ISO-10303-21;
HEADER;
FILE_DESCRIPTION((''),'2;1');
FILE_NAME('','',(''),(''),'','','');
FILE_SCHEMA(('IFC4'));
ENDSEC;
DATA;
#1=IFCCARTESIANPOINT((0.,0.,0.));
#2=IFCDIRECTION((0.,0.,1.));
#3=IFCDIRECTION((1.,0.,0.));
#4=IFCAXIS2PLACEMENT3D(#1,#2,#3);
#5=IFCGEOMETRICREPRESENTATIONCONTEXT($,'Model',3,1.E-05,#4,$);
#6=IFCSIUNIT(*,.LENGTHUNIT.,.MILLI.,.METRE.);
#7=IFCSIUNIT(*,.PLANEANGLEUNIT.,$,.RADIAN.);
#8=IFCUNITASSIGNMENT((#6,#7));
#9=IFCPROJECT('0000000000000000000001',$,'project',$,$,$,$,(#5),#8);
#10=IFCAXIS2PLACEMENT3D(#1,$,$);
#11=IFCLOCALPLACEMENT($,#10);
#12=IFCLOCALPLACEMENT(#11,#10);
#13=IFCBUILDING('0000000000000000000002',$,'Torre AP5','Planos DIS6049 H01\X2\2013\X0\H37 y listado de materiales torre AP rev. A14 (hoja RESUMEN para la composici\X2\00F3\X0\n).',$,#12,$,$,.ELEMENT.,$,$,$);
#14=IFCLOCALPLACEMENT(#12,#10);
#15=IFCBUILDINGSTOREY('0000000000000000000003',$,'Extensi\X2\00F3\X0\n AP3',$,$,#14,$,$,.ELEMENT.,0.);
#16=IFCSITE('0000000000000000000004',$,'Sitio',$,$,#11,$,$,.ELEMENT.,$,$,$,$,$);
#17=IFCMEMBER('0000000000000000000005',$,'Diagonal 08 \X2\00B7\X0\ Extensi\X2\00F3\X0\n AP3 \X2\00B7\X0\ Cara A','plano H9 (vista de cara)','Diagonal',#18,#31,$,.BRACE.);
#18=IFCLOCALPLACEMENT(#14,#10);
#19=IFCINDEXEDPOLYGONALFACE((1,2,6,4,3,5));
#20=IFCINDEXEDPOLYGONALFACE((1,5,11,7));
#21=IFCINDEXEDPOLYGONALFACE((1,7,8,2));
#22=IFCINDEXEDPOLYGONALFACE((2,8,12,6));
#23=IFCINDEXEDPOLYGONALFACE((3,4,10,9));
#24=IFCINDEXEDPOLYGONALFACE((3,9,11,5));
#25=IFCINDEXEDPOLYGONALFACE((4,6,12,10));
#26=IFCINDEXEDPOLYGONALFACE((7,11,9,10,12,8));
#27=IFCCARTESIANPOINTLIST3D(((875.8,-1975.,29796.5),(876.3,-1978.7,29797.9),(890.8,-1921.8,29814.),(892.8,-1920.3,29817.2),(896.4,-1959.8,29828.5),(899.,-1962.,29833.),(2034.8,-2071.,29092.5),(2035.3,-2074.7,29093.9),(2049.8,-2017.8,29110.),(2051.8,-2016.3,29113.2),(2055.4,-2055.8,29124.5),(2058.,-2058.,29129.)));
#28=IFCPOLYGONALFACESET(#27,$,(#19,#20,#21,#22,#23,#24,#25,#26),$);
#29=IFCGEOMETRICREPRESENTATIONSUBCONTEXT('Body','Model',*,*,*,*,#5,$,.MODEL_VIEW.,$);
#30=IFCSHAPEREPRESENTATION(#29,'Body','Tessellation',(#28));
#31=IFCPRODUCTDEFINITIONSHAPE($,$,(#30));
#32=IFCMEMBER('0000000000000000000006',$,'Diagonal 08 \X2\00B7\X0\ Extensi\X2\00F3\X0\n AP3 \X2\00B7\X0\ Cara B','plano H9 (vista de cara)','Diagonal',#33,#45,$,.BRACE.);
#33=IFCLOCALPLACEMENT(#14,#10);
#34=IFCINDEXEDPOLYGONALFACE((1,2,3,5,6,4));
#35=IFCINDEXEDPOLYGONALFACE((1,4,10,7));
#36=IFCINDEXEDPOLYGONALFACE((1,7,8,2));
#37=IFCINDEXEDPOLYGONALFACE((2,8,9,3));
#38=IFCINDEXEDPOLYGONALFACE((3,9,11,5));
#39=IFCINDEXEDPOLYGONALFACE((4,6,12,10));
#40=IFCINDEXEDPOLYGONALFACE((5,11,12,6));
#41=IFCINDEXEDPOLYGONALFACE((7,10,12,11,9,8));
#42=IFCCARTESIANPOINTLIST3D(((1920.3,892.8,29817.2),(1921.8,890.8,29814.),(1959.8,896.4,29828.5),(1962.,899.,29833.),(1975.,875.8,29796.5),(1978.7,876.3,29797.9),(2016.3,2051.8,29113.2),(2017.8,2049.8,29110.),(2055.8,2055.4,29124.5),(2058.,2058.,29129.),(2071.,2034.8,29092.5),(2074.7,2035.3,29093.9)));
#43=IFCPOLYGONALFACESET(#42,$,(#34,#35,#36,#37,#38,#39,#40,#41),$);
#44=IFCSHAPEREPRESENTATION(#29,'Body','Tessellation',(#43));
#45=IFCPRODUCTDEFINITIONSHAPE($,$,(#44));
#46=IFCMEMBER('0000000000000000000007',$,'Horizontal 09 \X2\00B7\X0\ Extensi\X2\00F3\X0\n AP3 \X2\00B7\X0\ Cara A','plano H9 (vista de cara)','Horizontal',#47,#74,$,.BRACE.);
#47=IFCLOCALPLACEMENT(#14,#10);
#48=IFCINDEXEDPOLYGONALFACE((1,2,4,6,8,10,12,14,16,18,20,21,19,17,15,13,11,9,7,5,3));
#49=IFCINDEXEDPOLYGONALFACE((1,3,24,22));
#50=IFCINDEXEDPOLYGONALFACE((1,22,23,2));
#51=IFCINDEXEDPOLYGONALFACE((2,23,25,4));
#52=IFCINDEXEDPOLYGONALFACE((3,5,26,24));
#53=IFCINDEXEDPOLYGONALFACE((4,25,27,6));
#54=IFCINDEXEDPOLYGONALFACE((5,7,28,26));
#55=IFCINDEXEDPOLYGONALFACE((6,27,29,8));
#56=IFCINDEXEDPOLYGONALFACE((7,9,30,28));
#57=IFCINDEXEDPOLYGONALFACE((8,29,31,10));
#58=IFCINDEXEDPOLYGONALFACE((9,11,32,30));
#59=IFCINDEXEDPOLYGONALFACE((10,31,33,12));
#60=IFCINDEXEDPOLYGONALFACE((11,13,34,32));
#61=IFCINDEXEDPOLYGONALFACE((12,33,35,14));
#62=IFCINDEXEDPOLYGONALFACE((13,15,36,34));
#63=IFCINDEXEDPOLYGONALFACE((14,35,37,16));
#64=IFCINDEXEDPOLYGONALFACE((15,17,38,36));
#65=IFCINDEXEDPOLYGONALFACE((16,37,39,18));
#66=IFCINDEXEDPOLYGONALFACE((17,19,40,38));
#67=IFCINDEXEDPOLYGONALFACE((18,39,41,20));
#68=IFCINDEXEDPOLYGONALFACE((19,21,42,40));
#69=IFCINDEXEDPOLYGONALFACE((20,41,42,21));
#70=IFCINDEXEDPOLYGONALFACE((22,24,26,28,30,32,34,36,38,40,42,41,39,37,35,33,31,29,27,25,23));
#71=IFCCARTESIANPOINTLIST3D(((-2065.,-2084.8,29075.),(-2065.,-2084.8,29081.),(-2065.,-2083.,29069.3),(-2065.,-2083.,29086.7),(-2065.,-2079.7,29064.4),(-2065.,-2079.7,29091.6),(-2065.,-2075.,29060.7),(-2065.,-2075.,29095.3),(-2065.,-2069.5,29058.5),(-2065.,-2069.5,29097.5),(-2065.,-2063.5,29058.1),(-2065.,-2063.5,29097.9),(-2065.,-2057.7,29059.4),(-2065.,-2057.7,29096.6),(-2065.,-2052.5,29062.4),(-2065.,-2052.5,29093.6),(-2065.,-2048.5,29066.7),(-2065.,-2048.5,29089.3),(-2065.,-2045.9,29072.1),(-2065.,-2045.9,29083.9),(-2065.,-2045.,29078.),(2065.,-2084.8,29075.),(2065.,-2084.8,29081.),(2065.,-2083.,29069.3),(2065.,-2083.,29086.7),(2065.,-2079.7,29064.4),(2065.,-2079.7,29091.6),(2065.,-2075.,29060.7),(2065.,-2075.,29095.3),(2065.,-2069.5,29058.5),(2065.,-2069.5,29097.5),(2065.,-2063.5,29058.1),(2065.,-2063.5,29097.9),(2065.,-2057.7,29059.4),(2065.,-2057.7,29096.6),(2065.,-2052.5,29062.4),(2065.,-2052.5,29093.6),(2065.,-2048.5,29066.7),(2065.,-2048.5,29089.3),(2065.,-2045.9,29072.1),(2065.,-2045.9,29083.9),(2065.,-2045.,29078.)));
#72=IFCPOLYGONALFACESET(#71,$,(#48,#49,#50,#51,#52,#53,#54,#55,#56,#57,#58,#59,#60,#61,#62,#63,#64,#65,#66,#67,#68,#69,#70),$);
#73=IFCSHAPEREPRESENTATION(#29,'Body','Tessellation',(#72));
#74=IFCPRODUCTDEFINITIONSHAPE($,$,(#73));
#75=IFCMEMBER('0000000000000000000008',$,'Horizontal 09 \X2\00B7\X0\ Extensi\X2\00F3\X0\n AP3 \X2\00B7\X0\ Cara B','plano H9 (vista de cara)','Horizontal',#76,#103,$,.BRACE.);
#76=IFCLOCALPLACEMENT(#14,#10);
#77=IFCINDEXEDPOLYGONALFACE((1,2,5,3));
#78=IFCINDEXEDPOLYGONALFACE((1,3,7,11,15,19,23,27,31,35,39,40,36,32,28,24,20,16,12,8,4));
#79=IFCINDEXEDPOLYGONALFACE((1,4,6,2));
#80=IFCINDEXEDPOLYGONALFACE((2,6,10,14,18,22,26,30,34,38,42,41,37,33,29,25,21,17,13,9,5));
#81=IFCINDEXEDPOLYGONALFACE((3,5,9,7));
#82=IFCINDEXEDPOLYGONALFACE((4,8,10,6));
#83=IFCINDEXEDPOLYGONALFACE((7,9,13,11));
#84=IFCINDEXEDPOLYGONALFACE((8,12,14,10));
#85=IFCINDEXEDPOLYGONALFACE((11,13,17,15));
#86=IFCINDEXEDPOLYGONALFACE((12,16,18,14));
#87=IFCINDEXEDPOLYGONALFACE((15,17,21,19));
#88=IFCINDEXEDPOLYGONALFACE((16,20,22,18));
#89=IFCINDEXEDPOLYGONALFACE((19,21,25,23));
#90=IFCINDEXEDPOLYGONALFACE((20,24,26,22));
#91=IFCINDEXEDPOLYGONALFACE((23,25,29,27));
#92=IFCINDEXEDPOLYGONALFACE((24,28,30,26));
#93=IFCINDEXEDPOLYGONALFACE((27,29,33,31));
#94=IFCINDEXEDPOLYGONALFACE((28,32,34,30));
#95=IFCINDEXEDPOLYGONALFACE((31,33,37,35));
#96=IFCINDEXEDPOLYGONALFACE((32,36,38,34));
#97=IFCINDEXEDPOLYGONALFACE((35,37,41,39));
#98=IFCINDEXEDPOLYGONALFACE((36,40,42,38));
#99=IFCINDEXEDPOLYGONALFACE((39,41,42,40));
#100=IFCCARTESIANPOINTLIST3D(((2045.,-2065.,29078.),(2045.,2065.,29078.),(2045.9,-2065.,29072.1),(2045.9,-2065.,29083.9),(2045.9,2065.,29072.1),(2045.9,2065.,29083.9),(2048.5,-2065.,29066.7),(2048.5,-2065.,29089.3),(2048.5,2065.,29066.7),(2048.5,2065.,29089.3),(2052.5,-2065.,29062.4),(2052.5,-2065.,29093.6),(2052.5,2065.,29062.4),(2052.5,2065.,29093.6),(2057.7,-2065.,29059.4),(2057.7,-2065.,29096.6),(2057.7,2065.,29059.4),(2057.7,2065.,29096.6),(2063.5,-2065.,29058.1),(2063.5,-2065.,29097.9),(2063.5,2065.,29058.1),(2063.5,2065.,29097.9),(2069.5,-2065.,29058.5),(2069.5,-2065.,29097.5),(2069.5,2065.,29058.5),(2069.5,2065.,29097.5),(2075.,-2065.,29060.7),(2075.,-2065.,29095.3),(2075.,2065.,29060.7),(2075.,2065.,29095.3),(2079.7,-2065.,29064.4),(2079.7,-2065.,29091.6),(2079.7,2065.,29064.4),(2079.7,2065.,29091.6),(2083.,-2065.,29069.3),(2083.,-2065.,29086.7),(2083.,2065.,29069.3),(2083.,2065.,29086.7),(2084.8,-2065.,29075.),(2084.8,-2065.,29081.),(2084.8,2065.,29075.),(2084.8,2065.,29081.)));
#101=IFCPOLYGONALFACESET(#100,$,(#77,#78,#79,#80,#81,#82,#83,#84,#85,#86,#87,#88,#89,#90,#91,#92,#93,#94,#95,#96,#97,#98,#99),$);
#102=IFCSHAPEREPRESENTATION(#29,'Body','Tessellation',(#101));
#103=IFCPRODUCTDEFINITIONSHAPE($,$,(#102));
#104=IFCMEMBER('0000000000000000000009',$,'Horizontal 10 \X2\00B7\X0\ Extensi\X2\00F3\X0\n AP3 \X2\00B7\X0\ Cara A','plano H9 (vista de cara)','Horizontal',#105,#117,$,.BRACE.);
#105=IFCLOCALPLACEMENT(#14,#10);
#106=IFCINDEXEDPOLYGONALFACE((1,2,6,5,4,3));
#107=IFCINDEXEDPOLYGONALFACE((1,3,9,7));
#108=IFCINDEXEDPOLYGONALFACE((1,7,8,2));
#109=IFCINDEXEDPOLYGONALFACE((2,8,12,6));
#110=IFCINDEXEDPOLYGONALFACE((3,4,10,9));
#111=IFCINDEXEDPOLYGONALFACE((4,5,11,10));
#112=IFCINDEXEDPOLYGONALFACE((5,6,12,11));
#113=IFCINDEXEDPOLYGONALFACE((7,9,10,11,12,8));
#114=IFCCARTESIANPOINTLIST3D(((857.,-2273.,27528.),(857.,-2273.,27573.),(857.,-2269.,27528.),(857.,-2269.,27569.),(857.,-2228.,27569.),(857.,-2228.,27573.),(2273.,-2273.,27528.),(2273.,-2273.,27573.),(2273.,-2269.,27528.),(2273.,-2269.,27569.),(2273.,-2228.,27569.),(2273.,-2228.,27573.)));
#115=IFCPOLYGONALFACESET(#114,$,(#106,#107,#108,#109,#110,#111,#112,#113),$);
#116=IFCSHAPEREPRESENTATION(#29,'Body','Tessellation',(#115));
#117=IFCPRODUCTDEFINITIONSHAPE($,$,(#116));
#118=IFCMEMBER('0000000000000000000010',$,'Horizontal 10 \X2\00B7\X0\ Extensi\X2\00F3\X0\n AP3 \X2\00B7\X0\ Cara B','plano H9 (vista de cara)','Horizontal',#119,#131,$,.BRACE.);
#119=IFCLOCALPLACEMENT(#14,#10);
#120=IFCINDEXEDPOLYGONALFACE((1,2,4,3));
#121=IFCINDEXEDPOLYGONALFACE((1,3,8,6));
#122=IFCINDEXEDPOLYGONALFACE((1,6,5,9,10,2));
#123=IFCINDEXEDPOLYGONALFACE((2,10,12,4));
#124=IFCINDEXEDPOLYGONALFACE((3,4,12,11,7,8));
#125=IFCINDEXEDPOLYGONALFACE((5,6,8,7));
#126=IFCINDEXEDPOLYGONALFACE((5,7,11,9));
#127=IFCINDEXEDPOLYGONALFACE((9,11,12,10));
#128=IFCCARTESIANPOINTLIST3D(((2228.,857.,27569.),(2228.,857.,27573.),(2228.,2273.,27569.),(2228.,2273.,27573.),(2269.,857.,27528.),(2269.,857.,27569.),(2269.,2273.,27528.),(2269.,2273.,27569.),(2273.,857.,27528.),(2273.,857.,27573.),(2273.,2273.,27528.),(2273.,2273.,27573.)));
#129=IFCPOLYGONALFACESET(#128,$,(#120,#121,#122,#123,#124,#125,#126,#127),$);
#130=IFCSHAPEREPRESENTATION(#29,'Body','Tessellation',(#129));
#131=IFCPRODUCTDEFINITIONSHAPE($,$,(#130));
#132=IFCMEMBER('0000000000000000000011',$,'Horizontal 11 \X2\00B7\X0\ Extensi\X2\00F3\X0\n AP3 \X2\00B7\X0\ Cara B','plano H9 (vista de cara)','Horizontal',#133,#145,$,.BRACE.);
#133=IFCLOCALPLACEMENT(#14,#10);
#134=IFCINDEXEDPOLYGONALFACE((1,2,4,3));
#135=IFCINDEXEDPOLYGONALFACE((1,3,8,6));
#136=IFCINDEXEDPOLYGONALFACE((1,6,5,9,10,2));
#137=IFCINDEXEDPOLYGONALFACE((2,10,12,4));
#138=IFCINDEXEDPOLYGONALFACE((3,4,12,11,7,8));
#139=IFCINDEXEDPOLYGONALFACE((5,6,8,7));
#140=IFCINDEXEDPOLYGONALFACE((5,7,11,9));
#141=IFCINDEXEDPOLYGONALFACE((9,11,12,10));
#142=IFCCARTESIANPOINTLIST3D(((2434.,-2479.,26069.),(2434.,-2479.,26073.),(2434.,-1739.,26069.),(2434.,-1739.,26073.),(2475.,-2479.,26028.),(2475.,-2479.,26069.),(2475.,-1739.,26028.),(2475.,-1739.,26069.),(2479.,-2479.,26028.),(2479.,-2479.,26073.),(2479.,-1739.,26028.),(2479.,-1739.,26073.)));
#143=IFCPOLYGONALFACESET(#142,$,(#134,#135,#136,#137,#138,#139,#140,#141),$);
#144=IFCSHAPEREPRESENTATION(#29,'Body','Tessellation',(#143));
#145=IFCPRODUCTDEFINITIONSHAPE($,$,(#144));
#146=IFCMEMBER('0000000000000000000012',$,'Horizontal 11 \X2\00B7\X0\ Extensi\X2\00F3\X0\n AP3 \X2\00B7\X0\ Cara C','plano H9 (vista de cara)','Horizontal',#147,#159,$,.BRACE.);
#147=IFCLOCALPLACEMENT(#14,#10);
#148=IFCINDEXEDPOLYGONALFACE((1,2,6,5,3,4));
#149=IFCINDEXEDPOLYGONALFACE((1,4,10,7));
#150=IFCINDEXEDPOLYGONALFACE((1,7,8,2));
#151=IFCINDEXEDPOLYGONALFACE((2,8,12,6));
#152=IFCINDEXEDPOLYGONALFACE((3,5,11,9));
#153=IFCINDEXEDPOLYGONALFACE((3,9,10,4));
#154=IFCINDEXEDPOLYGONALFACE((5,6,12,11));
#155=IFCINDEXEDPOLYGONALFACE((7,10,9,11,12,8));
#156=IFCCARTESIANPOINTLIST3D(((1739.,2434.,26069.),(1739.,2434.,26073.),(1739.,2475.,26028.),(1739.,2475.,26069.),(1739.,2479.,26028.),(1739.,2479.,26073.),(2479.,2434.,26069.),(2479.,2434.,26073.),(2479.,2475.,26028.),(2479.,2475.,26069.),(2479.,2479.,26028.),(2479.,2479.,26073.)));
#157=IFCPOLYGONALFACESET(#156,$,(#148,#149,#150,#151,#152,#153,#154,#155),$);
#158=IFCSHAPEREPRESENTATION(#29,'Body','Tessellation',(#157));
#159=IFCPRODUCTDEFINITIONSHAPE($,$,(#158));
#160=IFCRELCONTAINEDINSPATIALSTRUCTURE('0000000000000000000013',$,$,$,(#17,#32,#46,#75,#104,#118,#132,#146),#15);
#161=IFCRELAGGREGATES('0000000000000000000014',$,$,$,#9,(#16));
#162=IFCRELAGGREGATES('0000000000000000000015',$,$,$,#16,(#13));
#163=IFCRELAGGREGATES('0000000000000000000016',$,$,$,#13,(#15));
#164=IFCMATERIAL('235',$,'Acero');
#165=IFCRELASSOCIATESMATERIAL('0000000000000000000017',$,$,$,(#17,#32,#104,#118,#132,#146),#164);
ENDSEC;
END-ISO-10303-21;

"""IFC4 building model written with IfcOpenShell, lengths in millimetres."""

from ifc_helpers import new_model, si_unit, frame, frame_2d, origin, origin_with_axes, place, context, subcontext, project, spatial, circle, l_section, extrude, material, element, save


model = new_model("IFC4")

# Units and contexts
model_context = context("Model", 3, precision=1e-05, world=origin_with_axes())
body_context = subcontext(model_context, "Body", "Model", "MODEL_VIEW")
ifc_project = project(units=[si_unit("LENGTHUNIT", "METRE", prefix="MILLI"), si_unit("PLANEANGLEUNIT", "RADIAN")], contexts=[model_context])

# Site, building, storey
site_placement = place(None, origin())
site = spatial("IfcSite", under=ifc_project, at=site_placement, Name="Sitio", CompositionType="ELEMENT")
building_placement = place(site_placement, origin())
building = spatial("IfcBuilding", under=site, at=building_placement, Name="Torre AP5", Description="Planos DIS6049 H01–H37 y listado de materiales torre AP rev. A14 (hoja RESUMEN para la composición).", CompositionType="ELEMENT")
storey_placement = place(building_placement, origin())
storey = spatial("IfcBuildingStorey", under=building, at=storey_placement, Name="Extensión AP3", CompositionType="ELEMENT", Elevation=0.0)

# Members
ifc_material_1 = material(Name="235", Category="Acero")
for number, where, z_axis, x_axis, name in (
    (1, (2058.0, -2058.0, 29129.0), (-0.852549, 0.070617, 0.517855), (-0.137057, 0.925948, -0.351904), "Diagonal 08 · Extensión AP3 · Cara A"),
    (2, (2058.0, 2058.0, 29129.0), (-0.070617, -0.852549, 0.517855), (-0.925948, -0.137057, -0.351904), "Diagonal 08 · Extensión AP3 · Cara B"),
):
    element("IfcMember", number, at=place(storey_placement, frame(where, z_axis=z_axis, x_axis=x_axis)), inside=storey, material=ifc_material_1, Name=name, Description="plano H9 (vista de cara)", ObjectType="Diagonal", PredefinedType="BRACE", context=body_context, shape_type="SweptSolid", body=[
        extrude(l_section(Depth=45.0, Width=45.0, Thickness=4.0, at=frame_2d((22.5, 22.5))), None, (0.0, 0.0, 1.0), 1359.5),
    ])
for number, where, z_axis, x_axis, name in (
    (3, (2065.0, -2065.0, 29078.0), (-1.0, 0.0, 0.0), (0.0, 1.0, 0.0), "Horizontal 09 · Extensión AP3 · Cara A"),
    (4, (2065.0, 2065.0, 29078.0), (0.0, -1.0, 0.0), (-1.0, 0.0, 0.0), "Horizontal 09 · Extensión AP3 · Cara B"),
):
    element("IfcMember", number, at=place(storey_placement, frame(where, z_axis=z_axis, x_axis=x_axis)), inside=storey, Name=name, Description="plano H9 (vista de cara)", ObjectType="Horizontal", PredefinedType="BRACE", context=body_context, shape_type="SweptSolid", body=[
        extrude(circle(Radius=20.0), None, (0.0, 0.0, 1.0), 4130.0),
    ])
for number, where, z_axis, x_axis, name in (
    (5, (2273.0, -2273.0, 27573.0), (-1.0, 0.0, 0.0), (0.0, 1.0, 0.0), "Horizontal 10 · Extensión AP3 · Cara A"),
    (6, (2273.0, 2273.0, 27573.0), (0.0, -1.0, 0.0), (-1.0, 0.0, 0.0), "Horizontal 10 · Extensión AP3 · Cara B"),
):
    element("IfcMember", number, at=place(storey_placement, frame(where, z_axis=z_axis, x_axis=x_axis)), inside=storey, material=ifc_material_1, Name=name, Description="plano H9 (vista de cara)", ObjectType="Horizontal", PredefinedType="BRACE", context=body_context, shape_type="SweptSolid", body=[
        extrude(l_section(Depth=45.0, Width=45.0, Thickness=4.0, at=frame_2d((22.5, 22.5))), None, (0.0, 0.0, 1.0), 1416.0),
    ])
for number, where, z_axis, x_axis, name in (
    (7, (2479.0, -1739.0, 26073.0), (0.0, -1.0, 0.0), (-1.0, 0.0, 0.0), "Horizontal 11 · Extensión AP3 · Cara B"),
    (8, (1739.0, 2479.0, 26073.0), (1.0, 0.0, 0.0), (0.0, -1.0, 0.0), "Horizontal 11 · Extensión AP3 · Cara C"),
):
    element("IfcMember", number, at=place(storey_placement, frame(where, z_axis=z_axis, x_axis=x_axis)), inside=storey, material=ifc_material_1, Name=name, Description="plano H9 (vista de cara)", ObjectType="Horizontal", PredefinedType="BRACE", context=body_context, shape_type="SweptSolid", body=[
        extrude(l_section(Depth=45.0, Width=45.0, Thickness=4.0, at=frame_2d((22.5, 22.5))), None, (0.0, 0.0, 1.0), 740.0),
    ])

save(model, "model.ifc")
